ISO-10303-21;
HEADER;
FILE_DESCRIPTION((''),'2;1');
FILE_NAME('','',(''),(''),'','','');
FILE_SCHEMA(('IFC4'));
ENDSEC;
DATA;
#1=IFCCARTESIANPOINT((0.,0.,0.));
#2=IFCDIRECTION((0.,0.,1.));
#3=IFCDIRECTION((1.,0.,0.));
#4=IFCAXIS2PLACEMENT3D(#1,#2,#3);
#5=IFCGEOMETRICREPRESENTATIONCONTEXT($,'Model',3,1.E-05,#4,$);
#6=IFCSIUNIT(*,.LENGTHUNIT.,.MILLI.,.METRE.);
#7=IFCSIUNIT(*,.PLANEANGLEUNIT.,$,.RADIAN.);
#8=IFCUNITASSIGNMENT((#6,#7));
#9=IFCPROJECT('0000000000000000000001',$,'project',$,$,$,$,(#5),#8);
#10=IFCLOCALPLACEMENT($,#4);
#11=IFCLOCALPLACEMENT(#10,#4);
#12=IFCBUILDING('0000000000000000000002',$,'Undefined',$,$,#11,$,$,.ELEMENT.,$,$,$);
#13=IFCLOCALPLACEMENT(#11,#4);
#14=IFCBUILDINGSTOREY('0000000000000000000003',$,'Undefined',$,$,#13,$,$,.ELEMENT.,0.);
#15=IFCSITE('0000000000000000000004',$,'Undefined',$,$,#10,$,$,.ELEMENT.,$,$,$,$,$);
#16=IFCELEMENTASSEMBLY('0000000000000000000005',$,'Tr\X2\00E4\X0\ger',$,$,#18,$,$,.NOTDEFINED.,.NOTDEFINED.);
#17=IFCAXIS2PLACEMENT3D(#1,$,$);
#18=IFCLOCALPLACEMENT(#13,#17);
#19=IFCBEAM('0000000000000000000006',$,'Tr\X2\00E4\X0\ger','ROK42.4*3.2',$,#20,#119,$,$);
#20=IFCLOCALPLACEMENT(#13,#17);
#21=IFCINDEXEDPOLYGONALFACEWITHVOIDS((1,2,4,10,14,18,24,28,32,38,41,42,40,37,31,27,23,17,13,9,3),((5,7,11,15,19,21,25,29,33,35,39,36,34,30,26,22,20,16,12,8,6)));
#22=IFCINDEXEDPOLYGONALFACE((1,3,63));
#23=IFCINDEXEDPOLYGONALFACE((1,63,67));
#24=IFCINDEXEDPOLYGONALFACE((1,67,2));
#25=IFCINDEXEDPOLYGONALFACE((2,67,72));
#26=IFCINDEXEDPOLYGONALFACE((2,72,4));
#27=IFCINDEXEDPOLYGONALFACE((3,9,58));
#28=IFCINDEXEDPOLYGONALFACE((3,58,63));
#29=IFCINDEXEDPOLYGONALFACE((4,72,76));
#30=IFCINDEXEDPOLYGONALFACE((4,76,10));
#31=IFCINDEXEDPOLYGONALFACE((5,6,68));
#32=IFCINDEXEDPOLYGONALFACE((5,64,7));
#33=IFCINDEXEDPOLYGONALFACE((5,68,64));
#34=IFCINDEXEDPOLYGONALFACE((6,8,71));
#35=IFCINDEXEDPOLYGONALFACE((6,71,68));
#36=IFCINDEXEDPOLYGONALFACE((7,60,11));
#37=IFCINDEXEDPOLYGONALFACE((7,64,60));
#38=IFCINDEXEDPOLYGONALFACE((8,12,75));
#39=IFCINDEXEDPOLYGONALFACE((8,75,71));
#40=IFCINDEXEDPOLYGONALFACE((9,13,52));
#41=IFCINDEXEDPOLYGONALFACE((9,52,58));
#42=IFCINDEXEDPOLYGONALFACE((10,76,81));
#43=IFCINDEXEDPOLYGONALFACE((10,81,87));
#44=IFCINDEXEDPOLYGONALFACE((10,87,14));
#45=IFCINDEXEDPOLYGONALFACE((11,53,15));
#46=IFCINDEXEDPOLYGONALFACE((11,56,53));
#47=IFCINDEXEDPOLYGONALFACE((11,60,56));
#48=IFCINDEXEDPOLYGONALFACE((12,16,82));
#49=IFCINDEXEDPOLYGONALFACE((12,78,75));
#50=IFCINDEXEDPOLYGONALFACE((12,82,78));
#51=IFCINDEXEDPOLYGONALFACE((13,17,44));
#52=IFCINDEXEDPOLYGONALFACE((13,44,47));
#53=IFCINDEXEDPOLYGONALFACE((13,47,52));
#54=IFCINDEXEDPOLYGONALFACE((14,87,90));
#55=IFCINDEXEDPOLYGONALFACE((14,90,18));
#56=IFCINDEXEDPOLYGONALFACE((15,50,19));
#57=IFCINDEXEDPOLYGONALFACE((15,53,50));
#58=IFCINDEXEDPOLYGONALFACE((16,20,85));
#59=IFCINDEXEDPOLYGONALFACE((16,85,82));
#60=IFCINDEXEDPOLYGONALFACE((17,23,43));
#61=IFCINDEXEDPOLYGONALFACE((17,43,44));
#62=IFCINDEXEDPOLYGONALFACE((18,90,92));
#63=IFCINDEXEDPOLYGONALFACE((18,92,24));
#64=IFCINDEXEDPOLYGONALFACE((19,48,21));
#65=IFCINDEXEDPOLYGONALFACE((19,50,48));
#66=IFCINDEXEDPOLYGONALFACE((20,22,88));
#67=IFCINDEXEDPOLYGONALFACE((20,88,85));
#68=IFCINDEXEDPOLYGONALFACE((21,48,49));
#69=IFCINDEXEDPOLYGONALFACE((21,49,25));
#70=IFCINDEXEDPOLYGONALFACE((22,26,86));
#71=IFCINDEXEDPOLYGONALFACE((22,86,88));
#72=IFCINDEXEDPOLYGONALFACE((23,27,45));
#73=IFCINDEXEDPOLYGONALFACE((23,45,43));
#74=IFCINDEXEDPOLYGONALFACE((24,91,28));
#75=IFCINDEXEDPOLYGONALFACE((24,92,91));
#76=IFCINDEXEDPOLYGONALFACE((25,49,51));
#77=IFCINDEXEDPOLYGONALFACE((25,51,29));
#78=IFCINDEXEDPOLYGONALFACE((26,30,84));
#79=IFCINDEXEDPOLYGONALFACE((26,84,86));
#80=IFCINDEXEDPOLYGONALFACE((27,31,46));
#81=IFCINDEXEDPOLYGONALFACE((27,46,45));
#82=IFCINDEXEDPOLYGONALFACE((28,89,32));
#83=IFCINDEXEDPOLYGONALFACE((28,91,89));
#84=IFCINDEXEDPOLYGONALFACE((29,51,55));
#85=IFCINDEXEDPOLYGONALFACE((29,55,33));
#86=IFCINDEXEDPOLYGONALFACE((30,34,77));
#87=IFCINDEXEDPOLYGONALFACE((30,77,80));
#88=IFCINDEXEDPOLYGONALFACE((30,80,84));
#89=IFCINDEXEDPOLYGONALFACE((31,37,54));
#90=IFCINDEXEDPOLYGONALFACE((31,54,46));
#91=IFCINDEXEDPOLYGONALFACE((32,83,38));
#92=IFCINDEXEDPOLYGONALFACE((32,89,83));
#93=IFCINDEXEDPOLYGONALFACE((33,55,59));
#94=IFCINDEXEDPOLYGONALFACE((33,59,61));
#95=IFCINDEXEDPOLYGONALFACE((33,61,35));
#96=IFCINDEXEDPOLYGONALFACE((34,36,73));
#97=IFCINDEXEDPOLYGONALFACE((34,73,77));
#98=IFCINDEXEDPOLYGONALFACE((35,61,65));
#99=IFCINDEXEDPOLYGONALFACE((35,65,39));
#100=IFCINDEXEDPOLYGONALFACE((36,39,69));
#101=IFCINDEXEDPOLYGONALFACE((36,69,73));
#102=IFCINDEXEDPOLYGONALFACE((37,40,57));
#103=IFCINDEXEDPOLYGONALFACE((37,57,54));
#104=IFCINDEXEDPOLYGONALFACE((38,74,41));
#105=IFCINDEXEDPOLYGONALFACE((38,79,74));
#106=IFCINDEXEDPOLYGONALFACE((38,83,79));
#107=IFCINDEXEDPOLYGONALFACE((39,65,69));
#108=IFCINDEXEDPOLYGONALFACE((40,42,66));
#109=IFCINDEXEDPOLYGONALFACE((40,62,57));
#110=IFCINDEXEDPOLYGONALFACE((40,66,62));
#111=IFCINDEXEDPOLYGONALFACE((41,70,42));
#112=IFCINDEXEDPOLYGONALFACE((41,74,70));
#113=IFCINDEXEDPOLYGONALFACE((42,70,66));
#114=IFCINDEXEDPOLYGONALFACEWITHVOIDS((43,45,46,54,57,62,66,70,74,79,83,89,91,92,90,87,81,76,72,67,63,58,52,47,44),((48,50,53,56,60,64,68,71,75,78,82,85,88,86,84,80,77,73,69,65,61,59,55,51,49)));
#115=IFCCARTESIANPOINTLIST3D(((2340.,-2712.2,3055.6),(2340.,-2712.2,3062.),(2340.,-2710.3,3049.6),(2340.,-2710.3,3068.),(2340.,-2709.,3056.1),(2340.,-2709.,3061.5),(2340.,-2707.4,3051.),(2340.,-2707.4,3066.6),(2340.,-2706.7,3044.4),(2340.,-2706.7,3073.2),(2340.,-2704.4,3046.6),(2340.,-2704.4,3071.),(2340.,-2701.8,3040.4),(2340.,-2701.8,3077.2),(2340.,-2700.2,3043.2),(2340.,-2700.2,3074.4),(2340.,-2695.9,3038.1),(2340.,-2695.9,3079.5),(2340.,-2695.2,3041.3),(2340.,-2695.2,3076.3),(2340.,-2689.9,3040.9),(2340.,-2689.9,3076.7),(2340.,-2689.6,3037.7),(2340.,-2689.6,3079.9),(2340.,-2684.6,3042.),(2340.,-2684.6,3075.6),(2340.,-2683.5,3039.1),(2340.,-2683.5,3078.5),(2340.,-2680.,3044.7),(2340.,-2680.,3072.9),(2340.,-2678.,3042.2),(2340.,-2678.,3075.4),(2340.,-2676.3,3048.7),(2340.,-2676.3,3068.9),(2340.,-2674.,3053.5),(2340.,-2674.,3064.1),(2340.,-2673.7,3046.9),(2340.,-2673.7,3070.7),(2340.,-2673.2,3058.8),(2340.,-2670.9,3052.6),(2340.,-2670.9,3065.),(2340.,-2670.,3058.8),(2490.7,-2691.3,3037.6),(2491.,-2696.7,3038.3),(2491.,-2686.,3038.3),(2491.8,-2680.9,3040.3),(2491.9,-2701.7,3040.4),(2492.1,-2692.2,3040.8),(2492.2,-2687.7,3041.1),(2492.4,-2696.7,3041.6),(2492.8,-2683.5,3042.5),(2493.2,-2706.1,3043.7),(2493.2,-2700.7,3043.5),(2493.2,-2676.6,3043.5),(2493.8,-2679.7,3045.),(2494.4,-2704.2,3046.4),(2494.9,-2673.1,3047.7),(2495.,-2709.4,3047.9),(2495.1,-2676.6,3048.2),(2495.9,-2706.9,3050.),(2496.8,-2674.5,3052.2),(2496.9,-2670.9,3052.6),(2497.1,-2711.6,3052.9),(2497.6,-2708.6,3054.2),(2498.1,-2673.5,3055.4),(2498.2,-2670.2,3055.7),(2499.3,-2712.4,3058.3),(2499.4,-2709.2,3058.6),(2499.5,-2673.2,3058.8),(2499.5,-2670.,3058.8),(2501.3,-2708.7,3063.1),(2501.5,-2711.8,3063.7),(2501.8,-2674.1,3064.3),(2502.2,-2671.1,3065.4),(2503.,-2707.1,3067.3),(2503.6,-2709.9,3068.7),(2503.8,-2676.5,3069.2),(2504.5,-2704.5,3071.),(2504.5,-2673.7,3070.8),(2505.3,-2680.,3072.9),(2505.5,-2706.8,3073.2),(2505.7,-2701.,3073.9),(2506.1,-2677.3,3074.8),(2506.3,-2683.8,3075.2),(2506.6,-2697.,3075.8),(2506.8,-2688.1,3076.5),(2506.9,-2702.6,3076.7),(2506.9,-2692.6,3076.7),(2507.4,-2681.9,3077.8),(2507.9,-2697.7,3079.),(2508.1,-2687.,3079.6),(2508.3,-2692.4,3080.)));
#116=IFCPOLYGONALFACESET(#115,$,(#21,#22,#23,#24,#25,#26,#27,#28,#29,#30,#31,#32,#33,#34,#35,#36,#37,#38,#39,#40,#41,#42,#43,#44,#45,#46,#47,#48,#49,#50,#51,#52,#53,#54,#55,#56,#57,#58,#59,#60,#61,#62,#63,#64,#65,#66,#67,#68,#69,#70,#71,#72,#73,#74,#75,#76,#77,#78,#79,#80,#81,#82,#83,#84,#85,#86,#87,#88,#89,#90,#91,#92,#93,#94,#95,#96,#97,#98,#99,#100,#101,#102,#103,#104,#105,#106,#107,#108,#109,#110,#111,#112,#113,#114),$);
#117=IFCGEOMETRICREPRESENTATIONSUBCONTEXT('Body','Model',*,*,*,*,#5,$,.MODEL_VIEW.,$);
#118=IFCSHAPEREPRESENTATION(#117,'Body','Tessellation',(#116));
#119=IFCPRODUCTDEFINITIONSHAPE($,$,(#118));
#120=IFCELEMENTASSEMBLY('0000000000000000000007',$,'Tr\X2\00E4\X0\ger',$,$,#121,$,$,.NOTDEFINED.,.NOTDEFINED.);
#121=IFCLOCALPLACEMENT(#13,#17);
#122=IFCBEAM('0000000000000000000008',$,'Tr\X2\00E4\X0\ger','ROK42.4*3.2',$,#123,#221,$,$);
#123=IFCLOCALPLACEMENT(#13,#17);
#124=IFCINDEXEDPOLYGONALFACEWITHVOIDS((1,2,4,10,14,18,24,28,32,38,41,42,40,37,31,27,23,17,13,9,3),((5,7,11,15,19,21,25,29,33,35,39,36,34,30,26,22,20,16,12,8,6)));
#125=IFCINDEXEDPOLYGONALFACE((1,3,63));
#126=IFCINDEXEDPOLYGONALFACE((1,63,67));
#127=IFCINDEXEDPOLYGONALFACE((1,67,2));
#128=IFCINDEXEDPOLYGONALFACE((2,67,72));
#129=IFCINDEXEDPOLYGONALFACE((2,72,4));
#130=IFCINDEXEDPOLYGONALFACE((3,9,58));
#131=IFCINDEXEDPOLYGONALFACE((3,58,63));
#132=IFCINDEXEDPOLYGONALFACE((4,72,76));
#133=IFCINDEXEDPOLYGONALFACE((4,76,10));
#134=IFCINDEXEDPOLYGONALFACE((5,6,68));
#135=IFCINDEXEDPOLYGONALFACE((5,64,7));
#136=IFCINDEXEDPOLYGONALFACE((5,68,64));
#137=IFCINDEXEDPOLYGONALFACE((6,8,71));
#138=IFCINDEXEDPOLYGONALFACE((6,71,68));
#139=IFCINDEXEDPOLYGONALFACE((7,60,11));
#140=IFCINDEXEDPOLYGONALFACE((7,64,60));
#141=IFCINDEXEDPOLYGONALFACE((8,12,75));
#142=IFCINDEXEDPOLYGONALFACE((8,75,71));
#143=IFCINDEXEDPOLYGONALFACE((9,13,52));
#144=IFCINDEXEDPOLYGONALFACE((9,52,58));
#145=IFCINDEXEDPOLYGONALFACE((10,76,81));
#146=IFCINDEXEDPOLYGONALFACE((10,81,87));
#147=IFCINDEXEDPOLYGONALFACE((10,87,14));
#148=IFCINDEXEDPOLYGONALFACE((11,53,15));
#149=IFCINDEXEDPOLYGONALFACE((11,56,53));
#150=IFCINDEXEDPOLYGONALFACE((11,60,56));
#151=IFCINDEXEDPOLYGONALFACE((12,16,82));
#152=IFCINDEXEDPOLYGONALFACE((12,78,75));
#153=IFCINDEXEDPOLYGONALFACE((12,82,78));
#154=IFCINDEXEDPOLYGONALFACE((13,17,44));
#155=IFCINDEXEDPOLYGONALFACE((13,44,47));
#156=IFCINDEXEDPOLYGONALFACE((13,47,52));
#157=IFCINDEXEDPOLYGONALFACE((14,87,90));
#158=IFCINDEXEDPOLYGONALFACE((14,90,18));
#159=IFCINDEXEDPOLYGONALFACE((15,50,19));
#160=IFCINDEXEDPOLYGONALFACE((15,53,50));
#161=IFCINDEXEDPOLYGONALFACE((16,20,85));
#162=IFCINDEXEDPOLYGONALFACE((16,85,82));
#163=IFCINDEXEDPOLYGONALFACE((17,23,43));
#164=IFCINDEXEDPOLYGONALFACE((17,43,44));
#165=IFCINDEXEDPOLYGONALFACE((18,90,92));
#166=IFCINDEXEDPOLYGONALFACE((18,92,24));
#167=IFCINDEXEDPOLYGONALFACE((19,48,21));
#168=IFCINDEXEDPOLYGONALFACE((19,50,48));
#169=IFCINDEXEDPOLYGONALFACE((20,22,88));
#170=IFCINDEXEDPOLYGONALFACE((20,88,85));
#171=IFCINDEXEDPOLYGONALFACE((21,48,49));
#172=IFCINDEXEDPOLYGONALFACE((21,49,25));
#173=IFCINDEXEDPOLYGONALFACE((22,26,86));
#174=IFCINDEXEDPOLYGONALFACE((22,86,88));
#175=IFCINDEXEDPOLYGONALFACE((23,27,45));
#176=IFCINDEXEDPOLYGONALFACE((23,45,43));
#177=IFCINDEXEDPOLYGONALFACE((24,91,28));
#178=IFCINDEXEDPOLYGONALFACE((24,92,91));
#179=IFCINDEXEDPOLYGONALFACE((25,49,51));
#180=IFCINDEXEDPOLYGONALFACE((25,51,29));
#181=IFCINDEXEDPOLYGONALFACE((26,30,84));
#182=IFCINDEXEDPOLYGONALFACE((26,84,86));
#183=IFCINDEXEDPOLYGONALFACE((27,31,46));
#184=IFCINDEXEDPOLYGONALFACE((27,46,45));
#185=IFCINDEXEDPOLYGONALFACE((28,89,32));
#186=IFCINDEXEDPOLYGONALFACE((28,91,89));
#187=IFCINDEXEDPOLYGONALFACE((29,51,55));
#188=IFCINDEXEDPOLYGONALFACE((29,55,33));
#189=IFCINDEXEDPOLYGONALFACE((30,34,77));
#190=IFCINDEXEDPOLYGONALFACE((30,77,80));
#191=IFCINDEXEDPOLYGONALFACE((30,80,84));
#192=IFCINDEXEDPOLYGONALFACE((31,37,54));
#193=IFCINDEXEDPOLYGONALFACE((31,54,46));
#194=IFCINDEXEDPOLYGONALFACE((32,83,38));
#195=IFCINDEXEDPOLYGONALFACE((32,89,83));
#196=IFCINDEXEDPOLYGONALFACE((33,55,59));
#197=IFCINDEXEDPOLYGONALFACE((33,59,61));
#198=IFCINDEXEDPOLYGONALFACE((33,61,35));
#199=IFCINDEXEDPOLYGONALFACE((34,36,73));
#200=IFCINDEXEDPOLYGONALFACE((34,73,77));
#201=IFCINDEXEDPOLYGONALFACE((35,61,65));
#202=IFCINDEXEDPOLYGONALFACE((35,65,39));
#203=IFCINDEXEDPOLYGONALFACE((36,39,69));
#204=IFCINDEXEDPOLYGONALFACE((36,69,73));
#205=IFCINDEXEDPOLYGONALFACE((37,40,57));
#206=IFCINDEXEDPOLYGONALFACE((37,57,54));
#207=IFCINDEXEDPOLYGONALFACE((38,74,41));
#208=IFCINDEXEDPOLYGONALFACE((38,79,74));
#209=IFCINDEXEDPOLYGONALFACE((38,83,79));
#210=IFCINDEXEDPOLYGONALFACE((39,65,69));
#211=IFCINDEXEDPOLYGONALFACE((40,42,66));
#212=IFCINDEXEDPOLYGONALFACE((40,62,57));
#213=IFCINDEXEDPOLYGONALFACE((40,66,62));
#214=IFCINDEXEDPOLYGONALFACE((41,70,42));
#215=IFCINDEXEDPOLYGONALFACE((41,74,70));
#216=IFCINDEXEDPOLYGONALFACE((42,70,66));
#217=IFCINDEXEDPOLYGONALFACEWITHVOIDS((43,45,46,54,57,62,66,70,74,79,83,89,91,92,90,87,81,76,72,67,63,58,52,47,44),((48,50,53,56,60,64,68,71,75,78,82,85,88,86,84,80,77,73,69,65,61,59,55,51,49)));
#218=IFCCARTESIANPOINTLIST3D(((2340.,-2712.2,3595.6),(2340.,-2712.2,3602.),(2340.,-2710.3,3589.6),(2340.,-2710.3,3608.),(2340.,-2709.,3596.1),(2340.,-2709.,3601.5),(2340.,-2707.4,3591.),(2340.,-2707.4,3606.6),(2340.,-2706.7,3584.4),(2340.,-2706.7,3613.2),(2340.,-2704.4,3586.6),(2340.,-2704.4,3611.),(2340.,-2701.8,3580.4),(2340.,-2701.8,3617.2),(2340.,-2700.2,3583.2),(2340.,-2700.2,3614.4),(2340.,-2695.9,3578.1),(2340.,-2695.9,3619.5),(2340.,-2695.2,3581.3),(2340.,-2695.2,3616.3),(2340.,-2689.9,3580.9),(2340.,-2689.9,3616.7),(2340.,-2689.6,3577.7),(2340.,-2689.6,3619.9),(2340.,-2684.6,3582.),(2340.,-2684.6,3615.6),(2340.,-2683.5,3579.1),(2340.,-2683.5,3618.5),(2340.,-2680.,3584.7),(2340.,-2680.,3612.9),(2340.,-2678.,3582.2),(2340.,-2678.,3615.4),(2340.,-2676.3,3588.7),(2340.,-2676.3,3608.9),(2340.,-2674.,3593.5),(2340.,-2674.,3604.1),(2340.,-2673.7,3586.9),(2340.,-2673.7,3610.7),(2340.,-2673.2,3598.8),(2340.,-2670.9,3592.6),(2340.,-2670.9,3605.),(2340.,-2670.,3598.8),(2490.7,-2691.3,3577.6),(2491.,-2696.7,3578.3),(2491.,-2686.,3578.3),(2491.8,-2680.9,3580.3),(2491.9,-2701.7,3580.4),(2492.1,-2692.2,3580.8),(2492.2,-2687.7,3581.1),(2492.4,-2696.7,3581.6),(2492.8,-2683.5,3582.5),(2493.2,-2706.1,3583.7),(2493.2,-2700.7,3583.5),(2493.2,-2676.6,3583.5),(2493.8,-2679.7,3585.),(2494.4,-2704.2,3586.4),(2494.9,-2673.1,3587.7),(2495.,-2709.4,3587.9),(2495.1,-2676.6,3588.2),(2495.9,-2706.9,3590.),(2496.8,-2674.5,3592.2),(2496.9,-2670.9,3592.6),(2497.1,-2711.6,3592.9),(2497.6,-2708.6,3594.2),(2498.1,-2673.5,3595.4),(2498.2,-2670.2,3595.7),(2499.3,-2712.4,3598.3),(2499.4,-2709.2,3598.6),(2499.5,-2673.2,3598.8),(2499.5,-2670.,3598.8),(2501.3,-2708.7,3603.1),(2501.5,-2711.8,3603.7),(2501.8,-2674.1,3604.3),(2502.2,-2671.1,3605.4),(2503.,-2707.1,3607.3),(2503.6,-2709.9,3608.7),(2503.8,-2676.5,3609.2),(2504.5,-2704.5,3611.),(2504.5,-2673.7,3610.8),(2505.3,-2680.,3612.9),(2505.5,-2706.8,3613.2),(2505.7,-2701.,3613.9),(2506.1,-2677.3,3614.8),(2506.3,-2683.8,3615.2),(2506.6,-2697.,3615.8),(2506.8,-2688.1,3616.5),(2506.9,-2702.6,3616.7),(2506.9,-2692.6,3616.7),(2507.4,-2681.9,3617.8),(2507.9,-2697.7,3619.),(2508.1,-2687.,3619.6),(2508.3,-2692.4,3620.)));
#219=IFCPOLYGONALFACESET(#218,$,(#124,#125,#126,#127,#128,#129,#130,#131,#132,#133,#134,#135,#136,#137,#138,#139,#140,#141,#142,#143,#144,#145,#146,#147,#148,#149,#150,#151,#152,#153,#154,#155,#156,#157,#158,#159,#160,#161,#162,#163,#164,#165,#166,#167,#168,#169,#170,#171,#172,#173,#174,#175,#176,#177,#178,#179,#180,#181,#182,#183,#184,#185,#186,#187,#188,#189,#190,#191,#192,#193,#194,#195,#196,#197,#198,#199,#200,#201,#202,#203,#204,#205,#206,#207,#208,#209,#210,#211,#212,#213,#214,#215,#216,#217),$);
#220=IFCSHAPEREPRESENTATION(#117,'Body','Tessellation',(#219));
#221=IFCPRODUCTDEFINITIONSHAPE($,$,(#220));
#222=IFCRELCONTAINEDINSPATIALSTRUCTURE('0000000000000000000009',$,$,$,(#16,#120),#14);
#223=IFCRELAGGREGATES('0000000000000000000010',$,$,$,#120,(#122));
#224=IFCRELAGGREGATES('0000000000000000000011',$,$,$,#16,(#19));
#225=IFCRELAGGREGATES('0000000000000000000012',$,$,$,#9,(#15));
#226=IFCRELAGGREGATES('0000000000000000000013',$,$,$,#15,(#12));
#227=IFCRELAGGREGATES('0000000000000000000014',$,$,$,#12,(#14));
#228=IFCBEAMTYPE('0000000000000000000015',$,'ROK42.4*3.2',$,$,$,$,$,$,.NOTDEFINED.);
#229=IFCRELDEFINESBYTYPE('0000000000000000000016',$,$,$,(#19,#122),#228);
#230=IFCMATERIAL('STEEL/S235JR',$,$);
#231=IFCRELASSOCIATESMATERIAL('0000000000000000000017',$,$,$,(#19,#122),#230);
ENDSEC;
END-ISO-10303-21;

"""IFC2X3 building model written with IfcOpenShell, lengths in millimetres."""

from ifc_helpers import new_model, si_unit, frame, origin_with_axes, origin_2d_with_axis, place, context, subcontext, project, spatial, hollow_circle, extrude, clip, halfspace, material, type_object, element, aggregate, save


model = new_model("IFC2X3")

# Units and contexts
model_context = context("Model", 3, precision=1e-05, world=origin_with_axes())
body_context = subcontext(model_context, "Body", "Model", "MODEL_VIEW")
ifc_project = project(units=[si_unit("LENGTHUNIT", "METRE", prefix="MILLI"), si_unit("PLANEANGLEUNIT", "RADIAN")], contexts=[model_context])

# Site, building, storey
site_placement = place(None, origin_with_axes())
site = spatial("IfcSite", under=ifc_project, at=site_placement, Name="Undefined", CompositionType="ELEMENT")
building_placement = place(site_placement, origin_with_axes())
building = spatial("IfcBuilding", under=site, at=building_placement, Name="Undefined", CompositionType="ELEMENT")
storey_placement = place(building_placement, origin_with_axes())
storey = spatial("IfcBuildingStorey", under=building, at=storey_placement, Name="Undefined", CompositionType="ELEMENT", Elevation=0.0)

# Element assemblies, beams
assembly_1_placement = place(storey_placement, origin_with_axes())
assembly_1 = element("IfcElementAssembly", 1, at=assembly_1_placement, inside=storey, Name="Träger", AssemblyPlace="NOTDEFINED", PredefinedType="NOTDEFINED")
ifc_material_1 = material(Name="STEEL/S235JR")
beam_type = type_object("IfcBeamType", Name="ROK42.4*3.2", PredefinedType="NOTDEFINED")
beam_1_placement = place(assembly_1_placement, frame((2500.0, -2691.2, 3058.8), z_axis=(0.0, 0.0, 1.0), x_axis=(-1.0, 0.0, 0.0)))
beam_1 = element("IfcBeam", 2, at=beam_1_placement, type_object=beam_type, material=ifc_material_1, Name="Träger", Description="ROK42.4*3.2", context=body_context, shape_type="Clipping", body=[
    clip(extrude(hollow_circle(Radius=21.2, WallThickness=3.2, at=origin_2d_with_axis()), frame((160.0, 0.0, 0.0), z_axis=(-1.0, 0.0, 0.0), x_axis=(0.0, -1.0, 0.0)), (0.0, 0.0, 1.0), 168.4), halfspace(frame((-8.3, 0.0, 21.2), z_axis=(-0.923878, 0.0, -0.382686), x_axis=(0.0, -1.0, 0.0)), False)),
])
assembly_2_placement = place(storey_placement, origin_with_axes())
assembly_2 = element("IfcElementAssembly", 3, at=assembly_2_placement, inside=storey, Name="Träger", AssemblyPlace="NOTDEFINED", PredefinedType="NOTDEFINED")
beam_2_placement = place(assembly_2_placement, frame((2500.0, -2691.2, 3598.8), z_axis=(0.0, 0.0, 1.0), x_axis=(-1.0, 0.0, 0.0)))
beam_2 = element("IfcBeam", 4, at=beam_2_placement, type_object=beam_type, material=ifc_material_1, Name="Träger", Description="ROK42.4*3.2", context=body_context, shape_type="Clipping", body=[
    clip(extrude(hollow_circle(Radius=21.2, WallThickness=3.2, at=origin_2d_with_axis()), frame((160.0, 0.0, 0.0), z_axis=(-1.0, 0.0, 0.0), x_axis=(0.0, -1.0, 0.0)), (0.0, 0.0, 1.0), 168.4), halfspace(frame((-8.3, 0.0, 21.2), z_axis=(-0.923878, 0.0, -0.382686), x_axis=(0.0, -1.0, 0.0)), False)),
])

aggregate(assembly_2, [beam_2])
aggregate(assembly_1, [beam_1])

save(model, "model.ifc")
